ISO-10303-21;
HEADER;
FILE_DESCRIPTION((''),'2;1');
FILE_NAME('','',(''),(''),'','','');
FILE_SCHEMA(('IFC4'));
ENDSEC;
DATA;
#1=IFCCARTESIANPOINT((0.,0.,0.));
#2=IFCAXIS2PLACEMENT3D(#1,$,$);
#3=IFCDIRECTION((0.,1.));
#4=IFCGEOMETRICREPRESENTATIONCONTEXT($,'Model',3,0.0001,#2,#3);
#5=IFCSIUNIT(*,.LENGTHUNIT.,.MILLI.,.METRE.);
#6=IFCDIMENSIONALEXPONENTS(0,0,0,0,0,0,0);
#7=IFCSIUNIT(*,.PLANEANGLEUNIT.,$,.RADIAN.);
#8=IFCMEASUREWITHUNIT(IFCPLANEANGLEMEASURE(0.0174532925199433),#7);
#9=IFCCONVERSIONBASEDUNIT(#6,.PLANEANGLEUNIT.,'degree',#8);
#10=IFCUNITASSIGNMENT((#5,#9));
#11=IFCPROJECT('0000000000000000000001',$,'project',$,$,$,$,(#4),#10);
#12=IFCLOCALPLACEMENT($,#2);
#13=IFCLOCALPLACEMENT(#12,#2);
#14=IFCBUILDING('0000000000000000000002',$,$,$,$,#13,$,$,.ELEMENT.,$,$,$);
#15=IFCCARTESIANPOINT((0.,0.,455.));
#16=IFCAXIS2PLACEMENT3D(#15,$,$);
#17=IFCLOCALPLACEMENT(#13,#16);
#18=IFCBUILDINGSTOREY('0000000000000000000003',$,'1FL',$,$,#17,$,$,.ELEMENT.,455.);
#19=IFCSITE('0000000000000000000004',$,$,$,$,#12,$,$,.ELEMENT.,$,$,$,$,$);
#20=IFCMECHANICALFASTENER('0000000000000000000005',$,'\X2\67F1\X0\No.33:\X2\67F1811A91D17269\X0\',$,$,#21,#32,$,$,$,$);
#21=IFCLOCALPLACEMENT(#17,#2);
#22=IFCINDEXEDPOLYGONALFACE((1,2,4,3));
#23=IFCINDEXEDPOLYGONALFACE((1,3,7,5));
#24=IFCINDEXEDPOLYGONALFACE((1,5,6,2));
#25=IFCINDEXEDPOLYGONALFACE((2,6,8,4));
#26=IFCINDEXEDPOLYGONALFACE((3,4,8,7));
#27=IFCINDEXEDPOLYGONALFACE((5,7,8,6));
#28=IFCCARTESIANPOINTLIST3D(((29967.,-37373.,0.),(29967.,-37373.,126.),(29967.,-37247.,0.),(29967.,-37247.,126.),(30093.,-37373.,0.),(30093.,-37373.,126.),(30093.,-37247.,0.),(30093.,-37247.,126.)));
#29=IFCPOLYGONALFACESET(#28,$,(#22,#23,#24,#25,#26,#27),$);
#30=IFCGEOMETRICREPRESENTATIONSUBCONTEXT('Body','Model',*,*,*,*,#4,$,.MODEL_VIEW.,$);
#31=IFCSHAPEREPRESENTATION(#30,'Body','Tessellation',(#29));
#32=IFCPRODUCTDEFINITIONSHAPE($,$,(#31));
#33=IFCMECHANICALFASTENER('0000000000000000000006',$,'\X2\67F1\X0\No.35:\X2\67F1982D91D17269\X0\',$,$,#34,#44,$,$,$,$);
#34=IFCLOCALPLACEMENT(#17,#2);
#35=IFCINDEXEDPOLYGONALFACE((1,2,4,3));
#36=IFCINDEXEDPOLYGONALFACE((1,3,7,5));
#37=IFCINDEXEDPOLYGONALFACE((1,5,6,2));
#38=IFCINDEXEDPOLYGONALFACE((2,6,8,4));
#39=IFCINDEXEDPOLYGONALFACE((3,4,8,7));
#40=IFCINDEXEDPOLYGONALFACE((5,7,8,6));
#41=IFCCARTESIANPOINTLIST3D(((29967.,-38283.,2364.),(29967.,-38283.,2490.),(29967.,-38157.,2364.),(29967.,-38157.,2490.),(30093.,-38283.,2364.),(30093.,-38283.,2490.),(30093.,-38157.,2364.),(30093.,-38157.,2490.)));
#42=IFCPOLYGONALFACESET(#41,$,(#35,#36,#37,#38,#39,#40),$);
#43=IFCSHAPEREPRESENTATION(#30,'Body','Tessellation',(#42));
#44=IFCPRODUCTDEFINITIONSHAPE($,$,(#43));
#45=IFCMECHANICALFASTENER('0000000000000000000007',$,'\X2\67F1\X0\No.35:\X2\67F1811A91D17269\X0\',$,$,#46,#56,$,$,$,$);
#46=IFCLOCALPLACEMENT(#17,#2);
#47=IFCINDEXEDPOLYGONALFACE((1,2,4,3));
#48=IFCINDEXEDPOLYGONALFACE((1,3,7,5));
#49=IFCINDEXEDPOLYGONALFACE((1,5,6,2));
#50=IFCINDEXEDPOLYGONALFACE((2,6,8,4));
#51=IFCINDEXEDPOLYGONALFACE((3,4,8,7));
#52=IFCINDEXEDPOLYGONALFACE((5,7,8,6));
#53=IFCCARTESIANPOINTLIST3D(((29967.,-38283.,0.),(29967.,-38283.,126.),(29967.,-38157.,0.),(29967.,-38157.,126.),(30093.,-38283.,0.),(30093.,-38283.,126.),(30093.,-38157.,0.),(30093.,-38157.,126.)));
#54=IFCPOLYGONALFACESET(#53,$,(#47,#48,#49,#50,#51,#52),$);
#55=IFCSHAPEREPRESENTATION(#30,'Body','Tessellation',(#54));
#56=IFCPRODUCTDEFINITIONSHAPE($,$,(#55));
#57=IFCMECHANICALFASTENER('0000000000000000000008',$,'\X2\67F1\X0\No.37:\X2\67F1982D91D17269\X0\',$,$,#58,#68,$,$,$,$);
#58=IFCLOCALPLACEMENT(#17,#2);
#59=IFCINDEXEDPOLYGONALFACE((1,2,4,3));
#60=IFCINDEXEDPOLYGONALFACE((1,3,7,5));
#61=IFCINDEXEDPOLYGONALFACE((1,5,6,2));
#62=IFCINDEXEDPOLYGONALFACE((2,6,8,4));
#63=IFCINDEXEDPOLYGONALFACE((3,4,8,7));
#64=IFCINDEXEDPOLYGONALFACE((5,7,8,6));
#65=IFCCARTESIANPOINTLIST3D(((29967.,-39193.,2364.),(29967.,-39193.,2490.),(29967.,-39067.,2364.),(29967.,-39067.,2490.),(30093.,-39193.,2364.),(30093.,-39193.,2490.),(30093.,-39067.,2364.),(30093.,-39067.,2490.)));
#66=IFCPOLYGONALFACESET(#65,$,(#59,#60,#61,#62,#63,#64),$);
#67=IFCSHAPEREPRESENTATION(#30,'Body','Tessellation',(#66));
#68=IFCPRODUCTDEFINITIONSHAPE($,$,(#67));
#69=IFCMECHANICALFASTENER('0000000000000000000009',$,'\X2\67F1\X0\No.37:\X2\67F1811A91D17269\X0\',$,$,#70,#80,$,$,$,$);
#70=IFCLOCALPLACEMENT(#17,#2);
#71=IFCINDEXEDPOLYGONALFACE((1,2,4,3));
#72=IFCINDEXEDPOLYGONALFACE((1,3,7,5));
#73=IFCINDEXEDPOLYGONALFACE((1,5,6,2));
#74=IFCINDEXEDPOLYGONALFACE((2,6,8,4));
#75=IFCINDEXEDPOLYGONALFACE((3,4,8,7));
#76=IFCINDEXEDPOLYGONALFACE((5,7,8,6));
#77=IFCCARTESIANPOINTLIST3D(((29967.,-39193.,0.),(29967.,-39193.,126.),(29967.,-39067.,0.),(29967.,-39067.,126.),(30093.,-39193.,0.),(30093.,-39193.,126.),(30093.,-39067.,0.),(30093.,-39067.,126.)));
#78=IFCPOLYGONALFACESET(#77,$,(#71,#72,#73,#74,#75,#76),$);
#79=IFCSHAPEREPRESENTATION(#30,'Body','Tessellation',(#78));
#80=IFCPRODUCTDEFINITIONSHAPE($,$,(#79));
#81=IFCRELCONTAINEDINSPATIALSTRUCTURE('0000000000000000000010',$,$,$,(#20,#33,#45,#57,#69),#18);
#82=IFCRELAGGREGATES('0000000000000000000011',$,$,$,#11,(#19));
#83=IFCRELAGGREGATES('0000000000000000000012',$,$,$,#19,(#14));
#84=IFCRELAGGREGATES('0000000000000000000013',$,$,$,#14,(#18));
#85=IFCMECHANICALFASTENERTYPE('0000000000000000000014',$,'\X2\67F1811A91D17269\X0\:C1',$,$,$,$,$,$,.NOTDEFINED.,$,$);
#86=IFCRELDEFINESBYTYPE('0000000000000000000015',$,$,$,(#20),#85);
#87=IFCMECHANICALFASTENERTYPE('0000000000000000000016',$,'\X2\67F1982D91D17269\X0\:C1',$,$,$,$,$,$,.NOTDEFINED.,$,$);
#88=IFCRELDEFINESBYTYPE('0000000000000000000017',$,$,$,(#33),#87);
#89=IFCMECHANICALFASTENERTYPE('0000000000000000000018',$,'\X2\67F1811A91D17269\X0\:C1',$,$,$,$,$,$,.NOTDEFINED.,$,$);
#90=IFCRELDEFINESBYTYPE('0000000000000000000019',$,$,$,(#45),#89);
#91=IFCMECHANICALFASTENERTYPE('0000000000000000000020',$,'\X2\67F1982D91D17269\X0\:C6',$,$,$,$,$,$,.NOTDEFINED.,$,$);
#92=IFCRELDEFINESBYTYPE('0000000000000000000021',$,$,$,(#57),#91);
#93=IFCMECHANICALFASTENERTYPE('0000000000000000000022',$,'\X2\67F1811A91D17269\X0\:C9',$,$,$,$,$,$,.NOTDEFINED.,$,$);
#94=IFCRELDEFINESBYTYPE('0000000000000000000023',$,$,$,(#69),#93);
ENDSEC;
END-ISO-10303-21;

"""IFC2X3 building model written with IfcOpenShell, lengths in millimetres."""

from ifc_helpers import new_model, entity, si_unit, converted_unit, direction, frame, origin, origin_with_axes, origin_2d, place, context, subcontext, project, spatial, rectangle, extrude, type_object, element, save


model = new_model("IFC2X3")

# Units and contexts
model_context = context("Model", 3, precision=0.0001, world=origin(), true_north=direction((0.0, 1.0)))
body_context = subcontext(model_context, "Body", "Model", "MODEL_VIEW")
ifc_project = project(units=[si_unit("LENGTHUNIT", "METRE", prefix="MILLI"), converted_unit("PLANEANGLEUNIT", "degree", entity("IfcPlaneAngleMeasure", 0.0174532925199433), si_unit("PLANEANGLEUNIT", "RADIAN"), dimensions=[0, 0, 0, 0, 0, 0, 0])], contexts=[model_context])

# Site, building, storey
site_placement = place(None, origin())
site = spatial("IfcSite", under=ifc_project, at=site_placement, CompositionType="ELEMENT")
building_placement = place(site_placement, origin())
building = spatial("IfcBuilding", under=site, at=building_placement, CompositionType="ELEMENT")
storey_placement = place(building_placement, frame((0.0, 0.0, 455.0)))
storey = spatial("IfcBuildingStorey", under=building, at=storey_placement, Name="1FL", CompositionType="ELEMENT", Elevation=455.0)

# Mechanical fasteners
mechanical_fastener_type_1 = type_object("IfcMechanicalFastenerType", Name="柱脚金物:C1")
mechanical_fastener_1_placement = place(storey_placement, frame((30030.0, -37310.0, 0.0)))
element("IfcMechanicalFastener", 1, at=mechanical_fastener_1_placement, inside=storey, type_object=mechanical_fastener_type_1, Name="柱No.33:柱脚金物", context=body_context, shape_type="SweptSolid", body=[
    extrude(rectangle(XDim=126.0, YDim=126.0, at=origin_2d()), origin_with_axes(), (0.0, 0.0, 1.0), 126.0),
])
mechanical_fastener_type_2 = type_object("IfcMechanicalFastenerType", Name="柱頭金物:C1")
mechanical_fastener_2_placement = place(storey_placement, frame((30030.0, -38220.0, 2364.0)))
element("IfcMechanicalFastener", 2, at=mechanical_fastener_2_placement, inside=storey, type_object=mechanical_fastener_type_2, Name="柱No.35:柱頭金物", context=body_context, shape_type="SweptSolid", body=[
    extrude(rectangle(XDim=126.0, YDim=126.0, at=origin_2d()), origin_with_axes(), (0.0, 0.0, 1.0), 126.0),
])
mechanical_fastener_type_3 = type_object("IfcMechanicalFastenerType", Name="柱脚金物:C1")
mechanical_fastener_3_placement = place(storey_placement, frame((30030.0, -38220.0, 0.0)))
element("IfcMechanicalFastener", 3, at=mechanical_fastener_3_placement, inside=storey, type_object=mechanical_fastener_type_3, Name="柱No.35:柱脚金物", context=body_context, shape_type="SweptSolid", body=[
    extrude(rectangle(XDim=126.0, YDim=126.0, at=origin_2d()), origin_with_axes(), (0.0, 0.0, 1.0), 126.0),
])
mechanical_fastener_type_4 = type_object("IfcMechanicalFastenerType", Name="柱頭金物:C6")
mechanical_fastener_4_placement = place(storey_placement, frame((30030.0, -39130.0, 2364.0)))
element("IfcMechanicalFastener", 4, at=mechanical_fastener_4_placement, inside=storey, type_object=mechanical_fastener_type_4, Name="柱No.37:柱頭金物", context=body_context, shape_type="SweptSolid", body=[
    extrude(rectangle(XDim=126.0, YDim=126.0, at=origin_2d()), origin_with_axes(), (0.0, 0.0, 1.0), 126.0),
])
mechanical_fastener_type_5 = type_object("IfcMechanicalFastenerType", Name="柱脚金物:C9")
mechanical_fastener_5_placement = place(storey_placement, frame((30030.0, -39130.0, 0.0)))
element("IfcMechanicalFastener", 5, at=mechanical_fastener_5_placement, inside=storey, type_object=mechanical_fastener_type_5, Name="柱No.37:柱脚金物", context=body_context, shape_type="SweptSolid", body=[
    extrude(rectangle(XDim=126.0, YDim=126.0, at=origin_2d()), origin_with_axes(), (0.0, 0.0, 1.0), 126.0),
])

save(model, "model.ifc")
